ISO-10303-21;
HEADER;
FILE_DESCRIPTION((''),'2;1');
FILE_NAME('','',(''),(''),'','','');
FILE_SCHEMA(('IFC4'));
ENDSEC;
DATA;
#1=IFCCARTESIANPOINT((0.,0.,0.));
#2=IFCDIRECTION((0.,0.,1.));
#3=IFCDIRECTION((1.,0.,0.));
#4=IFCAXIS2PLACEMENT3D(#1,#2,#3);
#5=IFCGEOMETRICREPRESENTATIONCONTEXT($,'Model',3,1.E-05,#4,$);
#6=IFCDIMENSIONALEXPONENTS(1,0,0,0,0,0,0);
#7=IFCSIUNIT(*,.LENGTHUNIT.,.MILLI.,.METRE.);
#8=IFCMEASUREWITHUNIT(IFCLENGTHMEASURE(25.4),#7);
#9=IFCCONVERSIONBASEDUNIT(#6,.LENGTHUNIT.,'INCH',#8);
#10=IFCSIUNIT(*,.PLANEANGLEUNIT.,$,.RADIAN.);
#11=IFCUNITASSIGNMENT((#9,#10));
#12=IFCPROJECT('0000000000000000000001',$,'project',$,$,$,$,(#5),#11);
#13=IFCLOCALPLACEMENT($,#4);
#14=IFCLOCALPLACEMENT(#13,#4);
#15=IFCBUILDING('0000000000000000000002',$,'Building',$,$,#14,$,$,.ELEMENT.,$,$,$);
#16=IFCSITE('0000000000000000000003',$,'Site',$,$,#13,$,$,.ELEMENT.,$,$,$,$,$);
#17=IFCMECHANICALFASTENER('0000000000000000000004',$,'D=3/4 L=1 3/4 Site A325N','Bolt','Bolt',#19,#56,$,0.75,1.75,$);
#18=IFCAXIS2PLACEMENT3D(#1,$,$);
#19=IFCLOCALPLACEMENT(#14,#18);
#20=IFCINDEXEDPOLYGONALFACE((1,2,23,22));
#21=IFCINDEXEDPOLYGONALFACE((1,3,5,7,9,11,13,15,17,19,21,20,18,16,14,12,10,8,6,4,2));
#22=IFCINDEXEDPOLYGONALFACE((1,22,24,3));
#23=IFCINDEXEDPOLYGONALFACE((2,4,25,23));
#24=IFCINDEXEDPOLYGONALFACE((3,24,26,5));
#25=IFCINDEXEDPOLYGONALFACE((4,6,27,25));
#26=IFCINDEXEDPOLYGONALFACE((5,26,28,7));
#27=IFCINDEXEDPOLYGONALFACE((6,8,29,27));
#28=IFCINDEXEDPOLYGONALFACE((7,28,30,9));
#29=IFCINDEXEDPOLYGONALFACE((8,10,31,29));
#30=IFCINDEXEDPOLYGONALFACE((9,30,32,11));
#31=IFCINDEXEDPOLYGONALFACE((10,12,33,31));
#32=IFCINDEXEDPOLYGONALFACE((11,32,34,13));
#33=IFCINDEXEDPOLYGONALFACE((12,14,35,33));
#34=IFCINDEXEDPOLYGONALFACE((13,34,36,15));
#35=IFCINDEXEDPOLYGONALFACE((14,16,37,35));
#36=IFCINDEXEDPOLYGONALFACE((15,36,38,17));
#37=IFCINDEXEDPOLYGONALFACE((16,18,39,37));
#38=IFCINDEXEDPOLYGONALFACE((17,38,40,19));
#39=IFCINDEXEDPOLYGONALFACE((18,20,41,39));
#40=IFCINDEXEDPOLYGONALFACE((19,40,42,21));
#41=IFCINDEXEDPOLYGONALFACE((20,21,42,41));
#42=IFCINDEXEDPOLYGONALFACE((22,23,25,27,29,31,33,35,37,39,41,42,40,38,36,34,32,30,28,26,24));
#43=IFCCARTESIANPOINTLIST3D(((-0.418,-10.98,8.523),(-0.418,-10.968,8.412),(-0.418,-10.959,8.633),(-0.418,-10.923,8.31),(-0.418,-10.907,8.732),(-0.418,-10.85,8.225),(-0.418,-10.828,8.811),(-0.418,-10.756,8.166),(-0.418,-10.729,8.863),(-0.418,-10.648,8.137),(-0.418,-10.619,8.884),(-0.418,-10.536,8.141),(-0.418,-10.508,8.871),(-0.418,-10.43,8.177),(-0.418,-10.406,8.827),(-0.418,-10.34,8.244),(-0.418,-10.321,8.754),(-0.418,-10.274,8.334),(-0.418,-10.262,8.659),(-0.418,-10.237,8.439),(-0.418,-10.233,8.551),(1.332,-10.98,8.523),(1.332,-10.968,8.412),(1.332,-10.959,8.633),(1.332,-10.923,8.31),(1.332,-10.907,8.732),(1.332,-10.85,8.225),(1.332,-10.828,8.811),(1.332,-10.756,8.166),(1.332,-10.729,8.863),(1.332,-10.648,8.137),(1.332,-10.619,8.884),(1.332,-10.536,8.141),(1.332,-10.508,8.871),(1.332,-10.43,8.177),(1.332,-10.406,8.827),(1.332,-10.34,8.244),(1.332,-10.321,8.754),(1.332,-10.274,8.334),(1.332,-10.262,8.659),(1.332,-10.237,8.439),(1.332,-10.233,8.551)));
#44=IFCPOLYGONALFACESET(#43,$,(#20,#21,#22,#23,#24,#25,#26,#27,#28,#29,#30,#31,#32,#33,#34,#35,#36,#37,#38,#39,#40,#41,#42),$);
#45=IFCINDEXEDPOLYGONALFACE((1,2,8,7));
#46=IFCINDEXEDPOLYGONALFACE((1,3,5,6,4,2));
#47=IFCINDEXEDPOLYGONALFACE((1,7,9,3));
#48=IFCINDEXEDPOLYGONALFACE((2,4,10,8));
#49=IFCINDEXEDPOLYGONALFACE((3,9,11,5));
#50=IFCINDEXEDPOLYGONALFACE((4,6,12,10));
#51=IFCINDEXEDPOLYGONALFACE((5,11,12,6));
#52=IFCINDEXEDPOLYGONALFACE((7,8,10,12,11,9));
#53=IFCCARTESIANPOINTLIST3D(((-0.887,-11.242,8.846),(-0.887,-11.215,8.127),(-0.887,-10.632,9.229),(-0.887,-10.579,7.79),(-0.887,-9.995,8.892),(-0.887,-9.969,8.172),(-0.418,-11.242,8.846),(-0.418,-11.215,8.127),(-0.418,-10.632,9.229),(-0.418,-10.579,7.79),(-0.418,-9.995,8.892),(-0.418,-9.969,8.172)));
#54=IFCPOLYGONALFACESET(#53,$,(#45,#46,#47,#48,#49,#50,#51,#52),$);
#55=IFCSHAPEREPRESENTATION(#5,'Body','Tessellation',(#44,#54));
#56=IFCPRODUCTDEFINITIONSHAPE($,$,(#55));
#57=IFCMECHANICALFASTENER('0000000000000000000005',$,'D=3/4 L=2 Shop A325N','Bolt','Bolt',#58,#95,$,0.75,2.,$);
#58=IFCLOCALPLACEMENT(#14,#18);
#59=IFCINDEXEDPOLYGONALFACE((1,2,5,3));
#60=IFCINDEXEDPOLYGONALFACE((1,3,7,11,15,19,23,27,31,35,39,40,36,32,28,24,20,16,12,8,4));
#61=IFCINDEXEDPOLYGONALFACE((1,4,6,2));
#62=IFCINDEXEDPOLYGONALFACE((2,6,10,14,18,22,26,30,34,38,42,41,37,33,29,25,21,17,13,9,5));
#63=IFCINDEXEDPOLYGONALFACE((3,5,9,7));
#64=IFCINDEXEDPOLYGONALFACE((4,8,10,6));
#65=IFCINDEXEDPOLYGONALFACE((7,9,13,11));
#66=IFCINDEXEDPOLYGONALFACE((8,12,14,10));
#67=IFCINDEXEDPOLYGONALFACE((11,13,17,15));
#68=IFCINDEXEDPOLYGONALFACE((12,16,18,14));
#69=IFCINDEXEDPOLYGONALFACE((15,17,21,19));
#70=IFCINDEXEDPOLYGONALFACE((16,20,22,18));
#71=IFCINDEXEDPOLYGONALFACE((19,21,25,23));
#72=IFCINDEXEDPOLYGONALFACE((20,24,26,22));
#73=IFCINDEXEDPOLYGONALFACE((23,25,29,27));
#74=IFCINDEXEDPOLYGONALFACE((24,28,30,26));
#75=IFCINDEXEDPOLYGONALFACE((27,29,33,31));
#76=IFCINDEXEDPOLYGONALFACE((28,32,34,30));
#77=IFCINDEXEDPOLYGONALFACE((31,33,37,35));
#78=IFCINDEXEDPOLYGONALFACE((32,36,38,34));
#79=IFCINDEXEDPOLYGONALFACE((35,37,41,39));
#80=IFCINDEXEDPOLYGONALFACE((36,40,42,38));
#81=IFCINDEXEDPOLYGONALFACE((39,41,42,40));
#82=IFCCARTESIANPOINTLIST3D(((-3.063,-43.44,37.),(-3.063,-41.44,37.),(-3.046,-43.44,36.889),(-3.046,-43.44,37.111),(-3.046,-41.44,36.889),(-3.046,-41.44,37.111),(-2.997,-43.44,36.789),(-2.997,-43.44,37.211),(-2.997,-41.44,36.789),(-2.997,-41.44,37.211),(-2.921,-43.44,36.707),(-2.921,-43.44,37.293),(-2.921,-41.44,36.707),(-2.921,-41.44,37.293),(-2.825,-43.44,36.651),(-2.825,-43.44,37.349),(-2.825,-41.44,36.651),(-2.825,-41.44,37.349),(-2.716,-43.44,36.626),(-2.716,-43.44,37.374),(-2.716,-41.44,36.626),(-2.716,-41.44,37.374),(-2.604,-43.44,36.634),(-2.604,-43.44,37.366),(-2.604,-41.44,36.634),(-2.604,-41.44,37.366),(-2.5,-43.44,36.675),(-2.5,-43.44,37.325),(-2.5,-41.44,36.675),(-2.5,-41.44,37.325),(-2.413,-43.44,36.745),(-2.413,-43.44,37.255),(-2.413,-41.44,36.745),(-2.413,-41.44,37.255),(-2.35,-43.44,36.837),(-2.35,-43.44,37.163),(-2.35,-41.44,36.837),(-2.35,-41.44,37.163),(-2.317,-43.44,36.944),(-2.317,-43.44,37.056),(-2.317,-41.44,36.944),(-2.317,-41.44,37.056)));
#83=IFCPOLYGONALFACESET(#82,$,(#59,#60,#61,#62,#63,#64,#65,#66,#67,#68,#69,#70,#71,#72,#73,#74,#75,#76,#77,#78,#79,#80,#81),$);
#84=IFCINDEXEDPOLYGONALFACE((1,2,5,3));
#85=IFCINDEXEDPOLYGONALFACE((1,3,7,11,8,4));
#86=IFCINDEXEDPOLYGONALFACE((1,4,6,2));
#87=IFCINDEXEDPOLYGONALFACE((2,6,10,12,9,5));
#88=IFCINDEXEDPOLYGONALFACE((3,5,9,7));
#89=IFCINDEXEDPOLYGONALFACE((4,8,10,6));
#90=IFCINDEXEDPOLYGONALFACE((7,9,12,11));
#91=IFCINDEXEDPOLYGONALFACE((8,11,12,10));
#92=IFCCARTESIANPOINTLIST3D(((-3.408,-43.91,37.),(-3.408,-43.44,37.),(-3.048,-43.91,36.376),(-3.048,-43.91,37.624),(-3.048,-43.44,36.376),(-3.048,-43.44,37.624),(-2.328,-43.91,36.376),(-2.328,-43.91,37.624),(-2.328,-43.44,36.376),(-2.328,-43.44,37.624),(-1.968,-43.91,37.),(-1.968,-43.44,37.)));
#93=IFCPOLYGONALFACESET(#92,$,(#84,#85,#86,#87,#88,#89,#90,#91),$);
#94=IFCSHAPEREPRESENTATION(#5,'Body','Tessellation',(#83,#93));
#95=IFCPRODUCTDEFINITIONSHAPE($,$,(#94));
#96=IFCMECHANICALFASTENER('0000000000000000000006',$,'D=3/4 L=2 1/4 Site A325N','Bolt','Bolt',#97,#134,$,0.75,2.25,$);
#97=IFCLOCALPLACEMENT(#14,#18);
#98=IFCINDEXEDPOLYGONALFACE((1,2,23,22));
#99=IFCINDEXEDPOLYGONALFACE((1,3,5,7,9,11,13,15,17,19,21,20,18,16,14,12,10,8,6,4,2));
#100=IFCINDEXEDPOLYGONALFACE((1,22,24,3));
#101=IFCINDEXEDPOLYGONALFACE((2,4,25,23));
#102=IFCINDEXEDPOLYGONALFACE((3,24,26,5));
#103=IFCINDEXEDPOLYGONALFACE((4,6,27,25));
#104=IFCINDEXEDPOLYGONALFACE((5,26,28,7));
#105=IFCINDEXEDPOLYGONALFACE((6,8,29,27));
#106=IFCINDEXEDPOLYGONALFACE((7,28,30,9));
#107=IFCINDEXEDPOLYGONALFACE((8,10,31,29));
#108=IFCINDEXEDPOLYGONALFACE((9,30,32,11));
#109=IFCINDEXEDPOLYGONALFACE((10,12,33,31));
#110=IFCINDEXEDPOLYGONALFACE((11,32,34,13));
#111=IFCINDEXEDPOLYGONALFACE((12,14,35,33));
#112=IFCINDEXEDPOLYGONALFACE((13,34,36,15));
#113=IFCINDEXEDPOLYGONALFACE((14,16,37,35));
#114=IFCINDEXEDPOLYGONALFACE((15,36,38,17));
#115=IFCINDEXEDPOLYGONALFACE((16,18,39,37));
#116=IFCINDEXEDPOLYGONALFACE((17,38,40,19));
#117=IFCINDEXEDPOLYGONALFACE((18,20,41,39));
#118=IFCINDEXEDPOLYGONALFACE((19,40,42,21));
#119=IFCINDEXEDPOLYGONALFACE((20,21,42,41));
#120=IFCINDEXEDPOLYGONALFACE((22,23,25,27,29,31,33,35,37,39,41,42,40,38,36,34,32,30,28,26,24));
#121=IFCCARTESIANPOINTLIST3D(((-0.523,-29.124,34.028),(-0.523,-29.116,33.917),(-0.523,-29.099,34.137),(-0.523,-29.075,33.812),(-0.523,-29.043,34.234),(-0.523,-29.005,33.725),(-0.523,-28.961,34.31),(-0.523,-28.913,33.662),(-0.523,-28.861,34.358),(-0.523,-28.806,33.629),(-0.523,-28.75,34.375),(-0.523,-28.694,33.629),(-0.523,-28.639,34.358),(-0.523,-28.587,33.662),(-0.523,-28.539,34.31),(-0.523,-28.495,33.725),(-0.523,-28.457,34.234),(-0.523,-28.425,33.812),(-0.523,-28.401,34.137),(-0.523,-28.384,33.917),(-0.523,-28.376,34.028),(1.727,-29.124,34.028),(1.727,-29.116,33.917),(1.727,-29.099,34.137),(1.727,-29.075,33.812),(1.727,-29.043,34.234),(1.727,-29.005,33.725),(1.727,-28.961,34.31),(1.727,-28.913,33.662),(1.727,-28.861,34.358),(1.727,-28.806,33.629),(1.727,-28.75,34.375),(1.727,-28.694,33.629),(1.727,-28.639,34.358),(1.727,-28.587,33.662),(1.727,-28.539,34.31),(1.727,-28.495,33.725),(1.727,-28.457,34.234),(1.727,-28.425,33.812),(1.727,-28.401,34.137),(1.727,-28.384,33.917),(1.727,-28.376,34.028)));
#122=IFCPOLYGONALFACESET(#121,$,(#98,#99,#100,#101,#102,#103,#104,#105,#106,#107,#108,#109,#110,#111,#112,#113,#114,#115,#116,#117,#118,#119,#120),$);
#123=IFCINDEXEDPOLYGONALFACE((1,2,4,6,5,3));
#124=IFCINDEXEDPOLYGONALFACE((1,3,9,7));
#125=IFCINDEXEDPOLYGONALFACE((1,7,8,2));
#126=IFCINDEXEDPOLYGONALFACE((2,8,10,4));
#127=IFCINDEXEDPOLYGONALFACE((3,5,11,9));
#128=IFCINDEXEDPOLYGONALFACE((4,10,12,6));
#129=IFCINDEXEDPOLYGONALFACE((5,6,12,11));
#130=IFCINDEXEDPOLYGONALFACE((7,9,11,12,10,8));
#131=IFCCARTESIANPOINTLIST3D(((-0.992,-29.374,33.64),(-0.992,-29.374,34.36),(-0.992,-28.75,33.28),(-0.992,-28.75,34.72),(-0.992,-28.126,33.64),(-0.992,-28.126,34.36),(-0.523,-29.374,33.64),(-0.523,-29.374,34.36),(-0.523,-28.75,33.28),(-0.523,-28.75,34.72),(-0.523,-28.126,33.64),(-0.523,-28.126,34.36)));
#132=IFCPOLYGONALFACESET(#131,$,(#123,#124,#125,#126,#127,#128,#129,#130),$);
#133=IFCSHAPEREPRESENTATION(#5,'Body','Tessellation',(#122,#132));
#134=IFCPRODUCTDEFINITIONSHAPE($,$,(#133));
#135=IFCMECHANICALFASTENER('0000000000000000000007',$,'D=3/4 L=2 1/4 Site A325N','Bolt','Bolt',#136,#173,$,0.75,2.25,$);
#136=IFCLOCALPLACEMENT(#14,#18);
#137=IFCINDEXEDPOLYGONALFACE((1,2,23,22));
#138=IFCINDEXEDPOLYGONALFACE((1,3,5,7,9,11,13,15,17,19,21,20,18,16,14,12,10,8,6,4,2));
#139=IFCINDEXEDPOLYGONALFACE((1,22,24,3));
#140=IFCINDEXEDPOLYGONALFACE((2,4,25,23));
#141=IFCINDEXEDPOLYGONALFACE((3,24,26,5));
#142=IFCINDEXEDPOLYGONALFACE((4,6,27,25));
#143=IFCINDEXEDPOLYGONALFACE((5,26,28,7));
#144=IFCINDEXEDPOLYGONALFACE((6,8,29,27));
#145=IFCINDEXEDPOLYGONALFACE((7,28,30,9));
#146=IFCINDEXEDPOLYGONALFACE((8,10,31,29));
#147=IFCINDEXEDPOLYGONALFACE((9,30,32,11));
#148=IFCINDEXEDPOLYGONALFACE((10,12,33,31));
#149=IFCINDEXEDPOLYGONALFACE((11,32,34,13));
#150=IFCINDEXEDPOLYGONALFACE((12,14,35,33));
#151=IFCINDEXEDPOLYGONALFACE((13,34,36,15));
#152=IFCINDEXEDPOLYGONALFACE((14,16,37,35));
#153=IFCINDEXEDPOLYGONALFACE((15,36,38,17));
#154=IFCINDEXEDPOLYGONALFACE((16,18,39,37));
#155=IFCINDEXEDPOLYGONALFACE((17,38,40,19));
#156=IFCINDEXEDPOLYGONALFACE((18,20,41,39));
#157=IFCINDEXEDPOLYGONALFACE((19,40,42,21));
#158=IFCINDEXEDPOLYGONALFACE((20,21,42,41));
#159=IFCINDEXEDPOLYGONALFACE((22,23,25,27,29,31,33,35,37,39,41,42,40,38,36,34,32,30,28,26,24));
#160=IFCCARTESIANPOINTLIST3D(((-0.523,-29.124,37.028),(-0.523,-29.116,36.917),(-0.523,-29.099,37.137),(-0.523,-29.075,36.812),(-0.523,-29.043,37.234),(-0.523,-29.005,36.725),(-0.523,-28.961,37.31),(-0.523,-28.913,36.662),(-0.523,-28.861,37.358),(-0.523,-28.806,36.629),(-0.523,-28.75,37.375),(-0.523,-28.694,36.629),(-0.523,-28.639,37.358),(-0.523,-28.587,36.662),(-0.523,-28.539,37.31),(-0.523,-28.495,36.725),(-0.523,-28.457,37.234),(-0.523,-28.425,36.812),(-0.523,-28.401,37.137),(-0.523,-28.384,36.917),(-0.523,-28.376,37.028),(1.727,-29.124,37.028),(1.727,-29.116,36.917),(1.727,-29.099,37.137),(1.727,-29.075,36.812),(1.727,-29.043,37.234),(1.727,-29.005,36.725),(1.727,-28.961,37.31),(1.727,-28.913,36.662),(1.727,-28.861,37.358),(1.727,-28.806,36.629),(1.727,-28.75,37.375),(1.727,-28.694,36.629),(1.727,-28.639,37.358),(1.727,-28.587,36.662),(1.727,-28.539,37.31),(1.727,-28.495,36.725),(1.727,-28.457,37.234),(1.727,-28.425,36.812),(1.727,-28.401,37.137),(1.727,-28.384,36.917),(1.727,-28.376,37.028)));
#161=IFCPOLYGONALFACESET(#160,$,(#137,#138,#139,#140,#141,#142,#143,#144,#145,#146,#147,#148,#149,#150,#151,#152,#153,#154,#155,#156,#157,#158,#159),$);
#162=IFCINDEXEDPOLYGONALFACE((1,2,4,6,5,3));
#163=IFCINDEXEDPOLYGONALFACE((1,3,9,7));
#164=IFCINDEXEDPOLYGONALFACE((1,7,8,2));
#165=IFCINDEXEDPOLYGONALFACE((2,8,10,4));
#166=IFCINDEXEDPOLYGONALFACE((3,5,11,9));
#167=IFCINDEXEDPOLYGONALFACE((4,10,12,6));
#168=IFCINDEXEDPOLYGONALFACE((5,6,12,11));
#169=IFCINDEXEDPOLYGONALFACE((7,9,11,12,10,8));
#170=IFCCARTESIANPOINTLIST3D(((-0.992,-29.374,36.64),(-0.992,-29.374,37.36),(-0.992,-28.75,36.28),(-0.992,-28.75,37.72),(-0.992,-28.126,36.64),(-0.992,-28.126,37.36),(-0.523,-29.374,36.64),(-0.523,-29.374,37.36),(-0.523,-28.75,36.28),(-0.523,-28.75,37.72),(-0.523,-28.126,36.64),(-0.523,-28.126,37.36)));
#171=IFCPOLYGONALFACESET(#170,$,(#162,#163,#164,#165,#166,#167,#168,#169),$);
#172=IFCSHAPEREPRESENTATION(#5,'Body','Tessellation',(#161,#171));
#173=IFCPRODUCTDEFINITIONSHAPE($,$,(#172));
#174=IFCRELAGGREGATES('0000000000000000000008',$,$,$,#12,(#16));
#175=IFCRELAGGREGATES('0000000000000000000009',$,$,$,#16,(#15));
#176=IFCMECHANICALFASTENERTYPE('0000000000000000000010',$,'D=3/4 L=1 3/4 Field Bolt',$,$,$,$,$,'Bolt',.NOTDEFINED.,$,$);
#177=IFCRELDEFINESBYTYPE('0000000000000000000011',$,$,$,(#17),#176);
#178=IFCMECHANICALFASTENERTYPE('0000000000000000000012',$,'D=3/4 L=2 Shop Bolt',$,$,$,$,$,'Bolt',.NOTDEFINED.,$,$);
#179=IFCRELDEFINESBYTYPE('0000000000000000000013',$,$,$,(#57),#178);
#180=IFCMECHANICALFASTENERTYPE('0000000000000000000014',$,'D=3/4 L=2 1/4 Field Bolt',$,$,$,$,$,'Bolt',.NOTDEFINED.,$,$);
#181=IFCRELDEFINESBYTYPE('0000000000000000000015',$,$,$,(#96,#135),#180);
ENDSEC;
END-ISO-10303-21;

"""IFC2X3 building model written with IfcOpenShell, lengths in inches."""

from ifc_helpers import new_model, entity, si_unit, converted_unit, frame, origin_with_axes, origin_2d_with_axis, place, context, project, spatial, polyline, circle, outline, extrude, source, transform, mapped, type_object, type_shapes, element, save


model = new_model("IFC2X3")

# Units and contexts
model_context = context("Model", 3, precision=1e-05, world=origin_with_axes())
ifc_project = project(units=[converted_unit("LENGTHUNIT", "INCH", entity("IfcLengthMeasure", 25.4), si_unit("LENGTHUNIT", "METRE", prefix="MILLI"), dimensions=[1, 0, 0, 0, 0, 0, 0]), si_unit("PLANEANGLEUNIT", "RADIAN")], contexts=[model_context])

# Site, building
site_placement = place(None, origin_with_axes())
site = spatial("IfcSite", under=ifc_project, at=site_placement, Name="Site", CompositionType="ELEMENT")
building_placement = place(site_placement, origin_with_axes())
building = spatial("IfcBuilding", under=site, at=building_placement, Name="Building", CompositionType="ELEMENT")

# Shared definitions
assembly_1_placement = place(building_placement, frame((0.0, -27.0, 46.0), z_axis=(0.0, 0.0, 1.0), x_axis=(0.0, -1.0, 0.0)))

# Mechanical fasteners
mechanical_fastener_type_1 = type_object("IfcMechanicalFastenerType", Name="D=3/4 L=1 3/4 Field Bolt", ElementType="Bolt")
shared_shape_1 = source(origin_with_axes(), model_context, "Body", "SweptSolid", [
    extrude(circle(Radius=0.375, at=origin_2d_with_axis()), frame((0.0, 0.0, 0.0), z_axis=(1.0, 0.0, 0.0), x_axis=(0.0, 1.0, 0.0)), (0.0, 0.0, 1.0), 1.75),
    extrude(outline(polyline([(-0.72, 0.0), (-0.36, 0.624), (0.36, 0.624), (0.72, 0.0), (0.36, -0.624), (-0.36, -0.624), (-0.72, 0.0)])), frame((0.0, 0.0, 0.0), z_axis=(1.0, 0.0, 0.0), x_axis=(0.0, 1.0, 0.0)), (0.0, 0.0, -1.0), 0.47),
])
type_shapes(mechanical_fastener_type_1, [shared_shape_1])
placement_1 = place(building_placement, frame((-0.303, -6.355, 7.978), z_axis=(0.0, 0.470284, 0.882515), x_axis=(0.0, -0.882515, 0.470284)))
placement_2 = place(placement_1, frame((4.009, -0.115, 1.47), z_axis=(0.002713, 0.0, 0.999996), x_axis=(0.0, 1.0, 0.0)))
for number, where, z_axis, x_axis, name in (
    (1, (0.0, 0.0, -3.0), (0.0, 0.0, 1.0), (1.0, 0.0, 0.0), "D=3/4 L=1 3/4 Site A325N"),
):
    element("IfcMechanicalFastener", number, at=place(placement_2, frame(where, z_axis=z_axis, x_axis=x_axis)), type_object=mechanical_fastener_type_1, Name=name, Description="Bolt", ObjectType="Bolt", NominalDiameter=0.75, NominalLength=1.75, context=model_context, shape_type="MappedRepresentation", body=[
        mapped(shared_shape_1, transform((0.0, 0.0, 0.0), scale=1.0)),
    ])
mechanical_fastener_type_2 = type_object("IfcMechanicalFastenerType", Name="D=3/4 L=2 Shop Bolt", ElementType="Bolt")
shared_shape_2 = source(origin_with_axes(), model_context, "Body", "SweptSolid", [
    extrude(circle(Radius=0.375, at=origin_2d_with_axis()), frame((0.0, 0.0, 0.0), z_axis=(1.0, 0.0, 0.0), x_axis=(0.0, 1.0, 0.0)), (0.0, 0.0, 1.0), 2.0),
    extrude(outline(polyline([(-0.72, 0.0), (-0.36, 0.624), (0.36, 0.624), (0.72, 0.0), (0.36, -0.624), (-0.36, -0.624), (-0.72, 0.0)])), frame((0.0, 0.0, 0.0), z_axis=(1.0, 0.0, 0.0), x_axis=(0.0, 1.0, 0.0)), (0.0, 0.0, -1.0), 0.47),
])
type_shapes(mechanical_fastener_type_2, [shared_shape_2])
placement_3 = place(building_placement, frame((0.0, -43.0, 46.0), z_axis=(0.0, 0.0, 1.0), x_axis=(-1.0, 0.0, 0.0)))
placement_4 = place(placement_3, frame((2.688, 0.44, -9.0), z_axis=(0.0, 0.0, 1.0), x_axis=(0.0, -1.0, 0.0)))
mechanical_fastener_placement = place(placement_4, origin_with_axes())
element("IfcMechanicalFastener", 2, at=mechanical_fastener_placement, type_object=mechanical_fastener_type_2, Name="D=3/4 L=2 Shop A325N", Description="Bolt", ObjectType="Bolt", NominalDiameter=0.75, NominalLength=2.0, context=model_context, shape_type="MappedRepresentation", body=[
    mapped(shared_shape_2, transform((0.0, 0.0, 0.0), scale=1.0)),
])
mechanical_fastener_type_3 = type_object("IfcMechanicalFastenerType", Name="D=3/4 L=2 1/4 Field Bolt", ElementType="Bolt")
shared_shape_3 = source(origin_with_axes(), model_context, "Body", "SweptSolid", [
    extrude(circle(Radius=0.375, at=origin_2d_with_axis()), frame((0.0, 0.0, 0.0), z_axis=(1.0, 0.0, 0.0), x_axis=(0.0, 1.0, 0.0)), (0.0, 0.0, 1.0), 2.25),
    extrude(outline(polyline([(-0.72, 0.0), (-0.36, 0.624), (0.36, 0.624), (0.72, 0.0), (0.36, -0.624), (-0.36, -0.624), (-0.72, 0.0)])), frame((0.0, 0.0, 0.0), z_axis=(1.0, 0.0, 0.0), x_axis=(0.0, 1.0, 0.0)), (0.0, 0.0, -1.0), 0.47),
])
type_shapes(mechanical_fastener_type_3, [shared_shape_3])
placement_5 = place(assembly_1_placement, frame((1.75, -0.523, -3.0), z_axis=(1.0, 0.0, 0.0), x_axis=(0.0, 1.0, 0.0)))
for number, where, z_axis, x_axis, name in (
    (3, (0.0, -9.0, 0.0), (0.0, 0.0, 1.0), (1.0, 0.0, 0.0), "D=3/4 L=2 1/4 Site A325N"),
    (4, (0.0, -6.0, 0.0), (0.0, 0.0, 1.0), (1.0, 0.0, 0.0), "D=3/4 L=2 1/4 Site A325N"),
):
    element("IfcMechanicalFastener", number, at=place(placement_5, frame(where, z_axis=z_axis, x_axis=x_axis)), type_object=mechanical_fastener_type_3, Name=name, Description="Bolt", ObjectType="Bolt", NominalDiameter=0.75, NominalLength=2.25, context=model_context, shape_type="MappedRepresentation", body=[
        mapped(shared_shape_3, transform((0.0, 0.0, 0.0), scale=1.0)),
    ])

save(model, "model.ifc")
